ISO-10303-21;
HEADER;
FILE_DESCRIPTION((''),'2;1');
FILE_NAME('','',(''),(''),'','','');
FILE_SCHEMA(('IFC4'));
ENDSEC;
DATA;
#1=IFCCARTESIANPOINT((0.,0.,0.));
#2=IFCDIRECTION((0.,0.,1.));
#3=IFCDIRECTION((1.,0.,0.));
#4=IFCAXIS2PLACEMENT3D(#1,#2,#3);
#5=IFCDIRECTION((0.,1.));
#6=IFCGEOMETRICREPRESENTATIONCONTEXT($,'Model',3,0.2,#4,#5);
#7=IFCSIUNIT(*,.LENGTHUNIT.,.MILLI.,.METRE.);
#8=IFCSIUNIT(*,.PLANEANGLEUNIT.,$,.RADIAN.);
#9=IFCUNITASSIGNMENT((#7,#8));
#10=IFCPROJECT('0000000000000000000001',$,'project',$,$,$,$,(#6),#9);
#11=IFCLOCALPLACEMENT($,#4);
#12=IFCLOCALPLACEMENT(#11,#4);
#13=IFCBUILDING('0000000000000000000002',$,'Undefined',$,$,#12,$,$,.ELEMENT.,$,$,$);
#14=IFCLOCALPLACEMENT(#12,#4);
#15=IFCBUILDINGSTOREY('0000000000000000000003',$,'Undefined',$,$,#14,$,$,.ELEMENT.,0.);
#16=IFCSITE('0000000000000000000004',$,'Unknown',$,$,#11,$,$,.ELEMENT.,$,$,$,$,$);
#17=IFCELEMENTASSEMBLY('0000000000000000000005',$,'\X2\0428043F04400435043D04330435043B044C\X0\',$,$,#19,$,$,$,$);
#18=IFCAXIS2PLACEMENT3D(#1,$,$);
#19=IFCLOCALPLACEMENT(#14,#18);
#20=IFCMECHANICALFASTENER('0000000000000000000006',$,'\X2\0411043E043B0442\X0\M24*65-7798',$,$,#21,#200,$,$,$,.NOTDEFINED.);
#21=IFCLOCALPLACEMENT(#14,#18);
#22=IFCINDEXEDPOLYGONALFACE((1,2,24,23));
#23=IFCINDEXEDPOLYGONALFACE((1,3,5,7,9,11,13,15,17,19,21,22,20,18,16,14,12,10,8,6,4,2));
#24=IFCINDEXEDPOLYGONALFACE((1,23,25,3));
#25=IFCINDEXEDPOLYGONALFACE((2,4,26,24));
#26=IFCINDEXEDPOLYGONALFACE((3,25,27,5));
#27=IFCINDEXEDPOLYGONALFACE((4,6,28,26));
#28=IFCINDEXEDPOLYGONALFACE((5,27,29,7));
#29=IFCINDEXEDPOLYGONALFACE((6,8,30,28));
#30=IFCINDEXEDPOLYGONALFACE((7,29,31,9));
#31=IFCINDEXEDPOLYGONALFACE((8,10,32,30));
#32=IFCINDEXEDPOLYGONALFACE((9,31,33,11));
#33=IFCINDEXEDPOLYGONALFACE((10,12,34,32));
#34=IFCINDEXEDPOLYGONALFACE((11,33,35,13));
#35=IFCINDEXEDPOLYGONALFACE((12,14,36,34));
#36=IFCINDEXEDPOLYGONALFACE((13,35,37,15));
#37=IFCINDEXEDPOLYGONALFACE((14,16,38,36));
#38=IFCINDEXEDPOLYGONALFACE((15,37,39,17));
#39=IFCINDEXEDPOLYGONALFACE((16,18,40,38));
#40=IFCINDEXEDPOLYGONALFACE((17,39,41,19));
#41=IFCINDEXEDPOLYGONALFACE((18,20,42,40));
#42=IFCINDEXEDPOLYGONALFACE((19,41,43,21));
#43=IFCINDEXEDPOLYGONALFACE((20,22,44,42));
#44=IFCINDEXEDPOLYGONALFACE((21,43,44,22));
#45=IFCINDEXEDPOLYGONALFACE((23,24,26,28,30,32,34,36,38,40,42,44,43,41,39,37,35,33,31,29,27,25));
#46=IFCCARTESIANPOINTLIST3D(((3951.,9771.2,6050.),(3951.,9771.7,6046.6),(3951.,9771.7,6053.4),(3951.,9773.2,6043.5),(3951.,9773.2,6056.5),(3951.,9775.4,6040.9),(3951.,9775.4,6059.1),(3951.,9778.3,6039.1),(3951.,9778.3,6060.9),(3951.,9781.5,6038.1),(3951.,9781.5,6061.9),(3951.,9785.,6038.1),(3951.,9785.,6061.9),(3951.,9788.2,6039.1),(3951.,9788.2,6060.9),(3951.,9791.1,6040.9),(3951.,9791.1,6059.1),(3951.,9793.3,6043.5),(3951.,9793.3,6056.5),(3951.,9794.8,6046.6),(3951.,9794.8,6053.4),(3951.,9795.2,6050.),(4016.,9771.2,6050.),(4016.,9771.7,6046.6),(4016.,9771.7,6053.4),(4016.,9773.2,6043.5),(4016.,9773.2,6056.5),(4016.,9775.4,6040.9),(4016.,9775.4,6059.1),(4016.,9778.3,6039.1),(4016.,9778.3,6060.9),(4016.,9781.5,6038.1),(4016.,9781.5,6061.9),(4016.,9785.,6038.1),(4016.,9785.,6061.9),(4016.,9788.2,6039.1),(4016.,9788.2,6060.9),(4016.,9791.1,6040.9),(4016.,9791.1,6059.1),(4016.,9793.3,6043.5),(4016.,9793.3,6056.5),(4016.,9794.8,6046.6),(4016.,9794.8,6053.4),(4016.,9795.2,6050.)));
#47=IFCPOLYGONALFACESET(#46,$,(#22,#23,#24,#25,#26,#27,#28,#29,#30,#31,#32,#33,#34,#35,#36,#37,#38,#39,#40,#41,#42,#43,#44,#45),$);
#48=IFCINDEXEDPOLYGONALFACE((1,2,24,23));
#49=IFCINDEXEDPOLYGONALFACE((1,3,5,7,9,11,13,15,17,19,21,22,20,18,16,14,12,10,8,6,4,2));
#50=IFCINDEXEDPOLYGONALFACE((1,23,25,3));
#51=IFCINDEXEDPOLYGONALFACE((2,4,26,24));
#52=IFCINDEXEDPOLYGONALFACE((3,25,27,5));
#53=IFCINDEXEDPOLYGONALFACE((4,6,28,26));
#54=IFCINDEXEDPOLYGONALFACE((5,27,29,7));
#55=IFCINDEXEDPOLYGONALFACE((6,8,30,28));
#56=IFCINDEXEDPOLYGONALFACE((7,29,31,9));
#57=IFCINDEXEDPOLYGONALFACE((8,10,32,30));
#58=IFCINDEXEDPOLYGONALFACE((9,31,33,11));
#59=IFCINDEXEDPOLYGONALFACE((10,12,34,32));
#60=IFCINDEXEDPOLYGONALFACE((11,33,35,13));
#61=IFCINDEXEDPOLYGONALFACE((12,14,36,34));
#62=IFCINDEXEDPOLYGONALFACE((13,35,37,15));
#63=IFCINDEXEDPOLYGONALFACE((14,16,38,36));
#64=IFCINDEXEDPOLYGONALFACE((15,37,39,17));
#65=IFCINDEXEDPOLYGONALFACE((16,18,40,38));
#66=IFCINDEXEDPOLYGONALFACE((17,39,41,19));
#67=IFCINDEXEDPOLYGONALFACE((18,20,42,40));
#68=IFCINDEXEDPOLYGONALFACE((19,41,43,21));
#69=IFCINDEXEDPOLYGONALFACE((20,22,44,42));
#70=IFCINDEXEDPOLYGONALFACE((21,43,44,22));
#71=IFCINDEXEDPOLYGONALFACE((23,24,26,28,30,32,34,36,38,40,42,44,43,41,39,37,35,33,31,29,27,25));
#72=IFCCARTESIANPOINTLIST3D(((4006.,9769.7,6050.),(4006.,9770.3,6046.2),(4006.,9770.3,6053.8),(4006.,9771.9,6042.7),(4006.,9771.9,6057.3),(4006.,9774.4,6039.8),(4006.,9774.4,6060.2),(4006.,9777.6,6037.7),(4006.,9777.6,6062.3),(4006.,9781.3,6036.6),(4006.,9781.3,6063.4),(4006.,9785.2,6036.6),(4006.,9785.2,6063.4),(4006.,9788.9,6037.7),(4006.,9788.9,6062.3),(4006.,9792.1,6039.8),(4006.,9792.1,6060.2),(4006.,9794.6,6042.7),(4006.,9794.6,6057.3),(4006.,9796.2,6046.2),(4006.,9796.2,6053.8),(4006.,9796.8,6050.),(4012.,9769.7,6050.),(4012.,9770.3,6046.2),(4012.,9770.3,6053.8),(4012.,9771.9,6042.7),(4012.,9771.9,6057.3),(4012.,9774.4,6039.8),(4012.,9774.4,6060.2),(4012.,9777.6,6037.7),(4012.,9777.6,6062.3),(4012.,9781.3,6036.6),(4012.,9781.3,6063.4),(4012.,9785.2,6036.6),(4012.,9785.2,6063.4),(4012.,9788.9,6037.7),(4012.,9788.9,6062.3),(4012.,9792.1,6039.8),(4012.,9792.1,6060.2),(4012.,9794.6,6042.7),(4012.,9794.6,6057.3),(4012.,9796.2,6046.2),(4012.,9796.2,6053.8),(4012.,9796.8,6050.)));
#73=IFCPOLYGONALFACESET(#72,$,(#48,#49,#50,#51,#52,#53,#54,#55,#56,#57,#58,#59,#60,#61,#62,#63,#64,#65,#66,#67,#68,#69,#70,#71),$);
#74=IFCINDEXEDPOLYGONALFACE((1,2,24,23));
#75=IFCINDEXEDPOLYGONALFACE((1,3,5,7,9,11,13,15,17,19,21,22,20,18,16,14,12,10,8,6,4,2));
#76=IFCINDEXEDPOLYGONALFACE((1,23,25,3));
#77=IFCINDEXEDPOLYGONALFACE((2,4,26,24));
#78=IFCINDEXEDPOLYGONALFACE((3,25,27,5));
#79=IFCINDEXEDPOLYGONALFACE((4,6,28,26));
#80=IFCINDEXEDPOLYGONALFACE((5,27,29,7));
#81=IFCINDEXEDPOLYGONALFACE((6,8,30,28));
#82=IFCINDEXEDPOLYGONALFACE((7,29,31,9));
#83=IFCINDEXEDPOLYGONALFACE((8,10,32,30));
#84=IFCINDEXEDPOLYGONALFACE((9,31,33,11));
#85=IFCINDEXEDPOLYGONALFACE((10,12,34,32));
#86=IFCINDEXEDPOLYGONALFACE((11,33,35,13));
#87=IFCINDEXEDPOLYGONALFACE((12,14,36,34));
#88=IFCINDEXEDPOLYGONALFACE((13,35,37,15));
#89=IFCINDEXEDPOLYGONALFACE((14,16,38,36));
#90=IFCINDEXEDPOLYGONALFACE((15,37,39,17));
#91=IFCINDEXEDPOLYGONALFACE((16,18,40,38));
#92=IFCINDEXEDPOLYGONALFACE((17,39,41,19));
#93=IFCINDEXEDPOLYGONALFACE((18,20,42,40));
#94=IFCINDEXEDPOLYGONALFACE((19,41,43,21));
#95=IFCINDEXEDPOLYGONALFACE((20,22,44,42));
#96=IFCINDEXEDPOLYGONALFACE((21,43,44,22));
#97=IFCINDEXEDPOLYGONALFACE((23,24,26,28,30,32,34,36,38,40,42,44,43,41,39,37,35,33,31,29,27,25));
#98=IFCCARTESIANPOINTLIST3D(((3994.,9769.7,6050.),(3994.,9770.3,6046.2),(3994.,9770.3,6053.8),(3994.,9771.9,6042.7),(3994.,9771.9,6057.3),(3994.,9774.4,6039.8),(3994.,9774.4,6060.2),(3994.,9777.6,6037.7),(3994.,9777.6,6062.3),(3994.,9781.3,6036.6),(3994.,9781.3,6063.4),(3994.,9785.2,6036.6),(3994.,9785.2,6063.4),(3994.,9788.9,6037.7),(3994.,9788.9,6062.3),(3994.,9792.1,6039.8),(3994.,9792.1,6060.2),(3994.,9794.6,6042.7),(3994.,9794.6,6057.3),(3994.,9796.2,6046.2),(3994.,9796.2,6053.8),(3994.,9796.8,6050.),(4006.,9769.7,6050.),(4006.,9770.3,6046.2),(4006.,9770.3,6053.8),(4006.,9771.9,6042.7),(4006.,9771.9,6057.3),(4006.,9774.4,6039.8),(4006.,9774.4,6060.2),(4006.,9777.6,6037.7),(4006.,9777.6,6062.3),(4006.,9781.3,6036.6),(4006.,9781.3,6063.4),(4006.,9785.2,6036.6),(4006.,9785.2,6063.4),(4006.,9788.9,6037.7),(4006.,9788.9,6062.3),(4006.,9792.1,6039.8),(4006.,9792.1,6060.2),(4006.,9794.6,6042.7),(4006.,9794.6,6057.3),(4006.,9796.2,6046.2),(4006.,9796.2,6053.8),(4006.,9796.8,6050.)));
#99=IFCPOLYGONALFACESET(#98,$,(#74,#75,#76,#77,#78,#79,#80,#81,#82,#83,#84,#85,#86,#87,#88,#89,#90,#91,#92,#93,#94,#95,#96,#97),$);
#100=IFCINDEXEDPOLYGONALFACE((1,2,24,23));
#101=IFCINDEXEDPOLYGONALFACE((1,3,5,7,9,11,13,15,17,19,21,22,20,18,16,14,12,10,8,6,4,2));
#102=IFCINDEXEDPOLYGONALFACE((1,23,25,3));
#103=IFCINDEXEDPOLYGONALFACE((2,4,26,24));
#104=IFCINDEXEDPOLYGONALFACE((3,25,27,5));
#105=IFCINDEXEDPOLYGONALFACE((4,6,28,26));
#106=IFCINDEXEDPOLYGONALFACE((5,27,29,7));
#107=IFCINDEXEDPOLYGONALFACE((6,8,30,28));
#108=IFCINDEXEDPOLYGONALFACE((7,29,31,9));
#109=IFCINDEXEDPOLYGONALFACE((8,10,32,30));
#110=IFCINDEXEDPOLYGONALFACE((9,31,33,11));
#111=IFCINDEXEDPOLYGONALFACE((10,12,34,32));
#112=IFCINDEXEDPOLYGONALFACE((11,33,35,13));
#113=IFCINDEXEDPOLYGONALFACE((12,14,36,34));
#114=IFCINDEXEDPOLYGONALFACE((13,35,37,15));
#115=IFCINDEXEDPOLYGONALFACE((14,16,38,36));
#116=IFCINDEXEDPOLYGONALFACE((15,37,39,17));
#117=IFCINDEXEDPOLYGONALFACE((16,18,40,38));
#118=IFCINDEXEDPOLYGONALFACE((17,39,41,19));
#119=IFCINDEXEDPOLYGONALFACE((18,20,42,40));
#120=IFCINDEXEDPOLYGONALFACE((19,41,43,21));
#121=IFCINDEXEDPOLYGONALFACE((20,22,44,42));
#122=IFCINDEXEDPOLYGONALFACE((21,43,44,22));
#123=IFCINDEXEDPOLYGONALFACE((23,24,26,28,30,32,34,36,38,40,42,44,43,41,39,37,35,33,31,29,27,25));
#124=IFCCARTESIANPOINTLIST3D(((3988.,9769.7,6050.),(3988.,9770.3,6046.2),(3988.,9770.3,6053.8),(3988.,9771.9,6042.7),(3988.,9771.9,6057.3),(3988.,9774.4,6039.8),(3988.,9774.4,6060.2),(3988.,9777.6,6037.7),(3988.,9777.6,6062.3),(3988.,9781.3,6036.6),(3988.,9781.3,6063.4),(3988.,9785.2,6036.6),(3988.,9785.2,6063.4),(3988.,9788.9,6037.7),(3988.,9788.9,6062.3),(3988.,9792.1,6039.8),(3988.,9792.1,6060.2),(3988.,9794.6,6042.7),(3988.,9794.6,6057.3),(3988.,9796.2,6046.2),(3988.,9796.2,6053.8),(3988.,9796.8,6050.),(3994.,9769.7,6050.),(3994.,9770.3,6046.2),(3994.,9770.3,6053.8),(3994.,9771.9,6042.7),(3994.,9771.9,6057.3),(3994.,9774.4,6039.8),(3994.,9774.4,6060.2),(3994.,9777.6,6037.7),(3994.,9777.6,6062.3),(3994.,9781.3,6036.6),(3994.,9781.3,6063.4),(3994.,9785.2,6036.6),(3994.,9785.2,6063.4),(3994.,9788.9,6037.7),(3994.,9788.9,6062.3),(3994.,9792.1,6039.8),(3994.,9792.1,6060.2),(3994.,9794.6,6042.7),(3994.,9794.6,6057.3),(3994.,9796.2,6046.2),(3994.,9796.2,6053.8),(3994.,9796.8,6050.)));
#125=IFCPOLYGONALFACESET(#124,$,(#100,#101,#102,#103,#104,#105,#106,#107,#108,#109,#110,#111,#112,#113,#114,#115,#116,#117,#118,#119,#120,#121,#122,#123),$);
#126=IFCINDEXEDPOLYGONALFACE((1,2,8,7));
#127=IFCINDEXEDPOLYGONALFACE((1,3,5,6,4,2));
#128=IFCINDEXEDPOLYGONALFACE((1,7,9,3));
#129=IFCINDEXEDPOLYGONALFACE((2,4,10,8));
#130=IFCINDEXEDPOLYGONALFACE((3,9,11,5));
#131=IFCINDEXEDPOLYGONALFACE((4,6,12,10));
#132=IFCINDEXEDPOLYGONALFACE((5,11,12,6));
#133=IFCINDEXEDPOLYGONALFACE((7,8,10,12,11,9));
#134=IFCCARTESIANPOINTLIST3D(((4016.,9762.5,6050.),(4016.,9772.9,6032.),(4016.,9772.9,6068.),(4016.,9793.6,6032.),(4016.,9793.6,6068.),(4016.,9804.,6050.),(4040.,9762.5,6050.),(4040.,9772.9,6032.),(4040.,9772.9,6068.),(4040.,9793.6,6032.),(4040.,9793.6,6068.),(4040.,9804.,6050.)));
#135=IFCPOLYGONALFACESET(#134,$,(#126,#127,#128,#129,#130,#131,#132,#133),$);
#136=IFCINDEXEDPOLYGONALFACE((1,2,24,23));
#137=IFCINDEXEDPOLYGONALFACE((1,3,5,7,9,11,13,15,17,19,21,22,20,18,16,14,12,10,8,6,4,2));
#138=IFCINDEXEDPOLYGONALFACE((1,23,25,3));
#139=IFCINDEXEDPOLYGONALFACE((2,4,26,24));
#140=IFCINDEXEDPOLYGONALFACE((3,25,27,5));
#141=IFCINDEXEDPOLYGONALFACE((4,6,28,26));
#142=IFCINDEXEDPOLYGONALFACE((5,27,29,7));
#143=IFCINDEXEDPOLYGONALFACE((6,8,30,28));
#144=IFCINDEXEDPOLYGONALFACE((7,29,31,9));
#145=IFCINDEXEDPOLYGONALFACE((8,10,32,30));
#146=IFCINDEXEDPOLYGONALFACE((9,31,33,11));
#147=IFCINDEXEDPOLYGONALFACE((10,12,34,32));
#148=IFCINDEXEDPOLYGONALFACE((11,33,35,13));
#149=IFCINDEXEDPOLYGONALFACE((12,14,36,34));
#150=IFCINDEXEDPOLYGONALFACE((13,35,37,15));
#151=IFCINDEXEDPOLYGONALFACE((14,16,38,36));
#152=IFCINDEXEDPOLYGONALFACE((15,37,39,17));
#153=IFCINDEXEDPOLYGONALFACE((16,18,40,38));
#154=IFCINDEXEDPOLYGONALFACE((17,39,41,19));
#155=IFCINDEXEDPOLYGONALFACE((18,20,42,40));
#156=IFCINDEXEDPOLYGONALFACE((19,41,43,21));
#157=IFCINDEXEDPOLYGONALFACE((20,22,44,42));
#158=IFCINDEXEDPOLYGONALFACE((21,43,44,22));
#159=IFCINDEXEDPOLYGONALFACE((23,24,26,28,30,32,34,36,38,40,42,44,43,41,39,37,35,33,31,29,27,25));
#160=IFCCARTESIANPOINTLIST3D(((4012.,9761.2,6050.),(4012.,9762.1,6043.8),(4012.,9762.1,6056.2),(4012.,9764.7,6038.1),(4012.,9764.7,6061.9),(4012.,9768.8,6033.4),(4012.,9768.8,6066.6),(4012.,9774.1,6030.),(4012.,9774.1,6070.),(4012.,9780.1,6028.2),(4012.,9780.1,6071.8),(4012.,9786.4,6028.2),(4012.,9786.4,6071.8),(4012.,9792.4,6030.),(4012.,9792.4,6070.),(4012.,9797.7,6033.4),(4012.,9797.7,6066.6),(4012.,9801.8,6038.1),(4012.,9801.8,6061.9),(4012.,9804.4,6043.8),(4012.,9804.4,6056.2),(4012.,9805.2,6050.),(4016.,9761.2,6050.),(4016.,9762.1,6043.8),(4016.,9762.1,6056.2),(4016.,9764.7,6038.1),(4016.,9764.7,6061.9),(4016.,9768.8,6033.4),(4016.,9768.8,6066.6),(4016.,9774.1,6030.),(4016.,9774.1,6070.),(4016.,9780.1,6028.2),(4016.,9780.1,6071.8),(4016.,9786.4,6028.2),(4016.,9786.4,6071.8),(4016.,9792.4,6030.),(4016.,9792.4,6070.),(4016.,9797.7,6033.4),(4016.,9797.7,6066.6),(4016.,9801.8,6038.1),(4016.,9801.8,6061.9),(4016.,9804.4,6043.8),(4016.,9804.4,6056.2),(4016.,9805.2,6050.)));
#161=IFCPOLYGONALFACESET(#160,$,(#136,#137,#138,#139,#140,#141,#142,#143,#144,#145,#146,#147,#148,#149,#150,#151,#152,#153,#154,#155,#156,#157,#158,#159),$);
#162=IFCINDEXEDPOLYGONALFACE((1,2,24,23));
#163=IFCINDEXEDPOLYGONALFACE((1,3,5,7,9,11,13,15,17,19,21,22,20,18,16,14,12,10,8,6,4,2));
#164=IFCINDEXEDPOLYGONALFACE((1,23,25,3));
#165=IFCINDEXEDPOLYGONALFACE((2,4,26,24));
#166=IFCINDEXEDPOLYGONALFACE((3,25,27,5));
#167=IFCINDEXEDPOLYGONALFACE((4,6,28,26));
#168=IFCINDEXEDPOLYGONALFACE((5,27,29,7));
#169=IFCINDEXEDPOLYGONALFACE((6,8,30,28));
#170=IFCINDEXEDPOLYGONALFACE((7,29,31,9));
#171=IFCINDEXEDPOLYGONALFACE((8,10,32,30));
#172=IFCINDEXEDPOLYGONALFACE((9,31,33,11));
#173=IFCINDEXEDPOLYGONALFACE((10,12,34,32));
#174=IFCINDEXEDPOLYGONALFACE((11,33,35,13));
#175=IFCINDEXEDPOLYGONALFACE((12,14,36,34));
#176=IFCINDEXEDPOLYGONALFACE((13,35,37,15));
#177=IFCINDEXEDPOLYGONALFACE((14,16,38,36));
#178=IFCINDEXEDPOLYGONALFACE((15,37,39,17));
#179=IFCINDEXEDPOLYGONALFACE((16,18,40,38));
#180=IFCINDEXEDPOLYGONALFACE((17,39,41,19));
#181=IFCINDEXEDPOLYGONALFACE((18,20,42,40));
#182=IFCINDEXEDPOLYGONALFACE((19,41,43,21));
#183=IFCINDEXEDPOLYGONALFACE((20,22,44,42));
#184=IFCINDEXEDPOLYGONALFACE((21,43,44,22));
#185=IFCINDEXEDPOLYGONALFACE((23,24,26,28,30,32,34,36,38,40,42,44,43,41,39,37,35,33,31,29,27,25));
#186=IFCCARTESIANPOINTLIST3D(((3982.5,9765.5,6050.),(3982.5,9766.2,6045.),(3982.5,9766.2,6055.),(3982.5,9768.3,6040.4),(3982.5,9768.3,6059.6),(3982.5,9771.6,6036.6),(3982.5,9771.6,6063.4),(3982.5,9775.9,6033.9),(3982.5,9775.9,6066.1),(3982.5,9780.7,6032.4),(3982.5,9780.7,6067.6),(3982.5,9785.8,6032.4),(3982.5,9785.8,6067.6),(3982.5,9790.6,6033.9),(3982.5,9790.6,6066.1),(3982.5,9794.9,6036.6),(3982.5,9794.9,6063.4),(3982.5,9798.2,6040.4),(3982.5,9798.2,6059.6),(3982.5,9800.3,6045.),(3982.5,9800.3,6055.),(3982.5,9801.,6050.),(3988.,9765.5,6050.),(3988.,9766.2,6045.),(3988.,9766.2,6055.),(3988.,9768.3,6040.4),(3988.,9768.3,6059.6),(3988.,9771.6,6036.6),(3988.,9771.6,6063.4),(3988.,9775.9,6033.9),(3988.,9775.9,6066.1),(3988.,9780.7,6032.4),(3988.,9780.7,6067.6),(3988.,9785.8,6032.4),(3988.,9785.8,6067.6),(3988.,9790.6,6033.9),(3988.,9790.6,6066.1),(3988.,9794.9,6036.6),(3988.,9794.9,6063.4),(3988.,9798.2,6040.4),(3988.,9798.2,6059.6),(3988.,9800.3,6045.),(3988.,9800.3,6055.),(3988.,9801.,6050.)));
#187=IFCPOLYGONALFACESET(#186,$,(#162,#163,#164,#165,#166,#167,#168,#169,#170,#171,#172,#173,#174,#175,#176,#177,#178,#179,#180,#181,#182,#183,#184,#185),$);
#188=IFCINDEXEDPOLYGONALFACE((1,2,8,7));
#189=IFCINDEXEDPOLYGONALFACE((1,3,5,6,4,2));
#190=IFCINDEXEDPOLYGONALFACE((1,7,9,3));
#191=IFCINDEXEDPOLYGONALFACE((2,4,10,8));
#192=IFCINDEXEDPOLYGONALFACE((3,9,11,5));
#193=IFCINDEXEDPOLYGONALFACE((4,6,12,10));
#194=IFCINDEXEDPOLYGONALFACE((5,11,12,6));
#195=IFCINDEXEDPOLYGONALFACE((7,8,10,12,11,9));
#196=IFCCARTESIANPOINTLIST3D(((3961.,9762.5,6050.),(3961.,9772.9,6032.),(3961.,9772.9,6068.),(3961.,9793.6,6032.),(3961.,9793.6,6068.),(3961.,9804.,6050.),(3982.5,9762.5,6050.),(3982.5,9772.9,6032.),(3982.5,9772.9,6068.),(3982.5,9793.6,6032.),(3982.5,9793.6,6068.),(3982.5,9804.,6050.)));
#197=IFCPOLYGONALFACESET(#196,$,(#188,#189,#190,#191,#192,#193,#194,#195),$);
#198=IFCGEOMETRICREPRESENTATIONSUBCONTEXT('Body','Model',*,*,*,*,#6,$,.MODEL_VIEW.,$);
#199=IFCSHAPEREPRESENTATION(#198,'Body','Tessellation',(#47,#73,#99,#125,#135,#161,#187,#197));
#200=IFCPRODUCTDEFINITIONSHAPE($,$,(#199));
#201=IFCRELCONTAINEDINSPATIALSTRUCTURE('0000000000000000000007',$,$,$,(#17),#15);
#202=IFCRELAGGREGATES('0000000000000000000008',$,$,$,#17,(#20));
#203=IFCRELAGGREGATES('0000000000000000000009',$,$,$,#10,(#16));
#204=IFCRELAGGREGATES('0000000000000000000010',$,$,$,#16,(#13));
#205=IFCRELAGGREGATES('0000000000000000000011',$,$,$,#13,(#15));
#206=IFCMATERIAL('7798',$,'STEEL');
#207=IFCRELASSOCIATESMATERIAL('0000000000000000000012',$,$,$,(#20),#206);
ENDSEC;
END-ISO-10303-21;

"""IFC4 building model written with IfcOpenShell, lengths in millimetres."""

from ifc_helpers import new_model, si_unit, direction, frame, origin_with_axes, place, context, subcontext, project, spatial, line, arc, indexed_curve, outline, extrude, source, transform, mapped, material, element, aggregate, save


model = new_model("IFC4")

# Units and contexts
model_context = context("Model", 3, precision=0.2, world=origin_with_axes(), true_north=direction((0.0, 1.0)))
body_context = subcontext(model_context, "Body", "Model", "MODEL_VIEW")
ifc_project = project(units=[si_unit("LENGTHUNIT", "METRE", prefix="MILLI"), si_unit("PLANEANGLEUNIT", "RADIAN")], contexts=[model_context])

# Site, building, storey
site_placement = place(None, origin_with_axes())
site = spatial("IfcSite", under=ifc_project, at=site_placement, Name="Unknown", CompositionType="ELEMENT")
building_placement = place(site_placement, origin_with_axes())
building = spatial("IfcBuilding", under=site, at=building_placement, Name="Undefined", CompositionType="ELEMENT")
storey_placement = place(building_placement, origin_with_axes())
storey = spatial("IfcBuildingStorey", under=building, at=storey_placement, Name="Undefined", CompositionType="ELEMENT", Elevation=0.0)

# Shared definitions
ifc_material_1 = material(Name="7798", Category="STEEL")

# Element assembly, mechanical fastener
assembly_1_placement = place(storey_placement, frame((3949.0, 5673.0, 6045.0), z_axis=(0.0, 0.0, 1.0), x_axis=(0.0, 1.0, 0.0)))
assembly_1 = element("IfcElementAssembly", 1, at=assembly_1_placement, inside=storey, Name="Шпренгель")
shared_shape_1 = source(origin_with_axes(), body_context, "Body", "SweptSolid", [
    extrude(outline(indexed_curve([(12.0, 0.0), (0.0, 12.0), (-12.0, 0.0), (0.0, -12.0)], segments=[arc(1, 2, 3), arc(3, 4, 1)])), frame((0.0, 0.0, 16.0), z_axis=(0.0, 0.0, -1.0), x_axis=(0.0, 1.0, 0.0)), (0.0, 0.0, 1.0), 65.0),
    extrude(outline(indexed_curve([(13.5, 0.0), (0.0, 13.5), (-13.5, 0.0), (0.0, -13.5)], segments=[arc(1, 2, 3), arc(3, 4, 1)])), frame((0.0, 0.0, 12.0), z_axis=(0.0, 0.0, -1.0), x_axis=(0.0, 1.0, 0.0)), (0.0, 0.0, 1.0), 6.0),
    extrude(outline(indexed_curve([(13.5, 0.0), (0.0, 13.5), (-13.5, 0.0), (0.0, -13.5)], segments=[arc(1, 2, 3), arc(3, 4, 1)])), frame((0.0, 0.0, 6.0), z_axis=(0.0, 0.0, -1.0), x_axis=(0.0, 1.0, 0.0)), (0.0, 0.0, 1.0), 12.0),
    extrude(outline(indexed_curve([(13.5, 0.0), (0.0, 13.5), (-13.5, 0.0), (0.0, -13.5)], segments=[arc(1, 2, 3), arc(3, 4, 1)])), frame((0.0, 0.0, -6.0), z_axis=(0.0, 0.0, -1.0), x_axis=(0.0, 1.0, 0.0)), (0.0, 0.0, 1.0), 6.0),
    extrude(outline(indexed_curve([(20.8, 0.0), (10.4, 18.0), (-10.4, 18.0), (-20.8, 0.0), (-10.4, -18.0), (10.4, -18.0)], segments=[line(1, 2, 3, 4, 5, 6, 1)])), frame((0.0, 0.0, 40.0), z_axis=(0.0, 0.0, -1.0), x_axis=(0.0, 1.0, 0.0)), (0.0, 0.0, 1.0), 24.0),
    extrude(outline(indexed_curve([(22.0, 0.0), (0.0, 22.0), (-22.0, 0.0), (0.0, -22.0)], segments=[arc(1, 2, 3), arc(3, 4, 1)])), frame((0.0, 0.0, 16.0), z_axis=(0.0, 0.0, -1.0), x_axis=(0.0, 1.0, 0.0)), (0.0, 0.0, 1.0), 4.0),
    extrude(outline(indexed_curve([(17.8, 0.0), (0.0, 17.8), (-17.8, 0.0), (0.0, -17.8)], segments=[arc(1, 2, 3), arc(3, 4, 1)])), frame((0.0, 0.0, -12.0), z_axis=(0.0, 0.0, -1.0), x_axis=(0.0, 1.0, 0.0)), (0.0, 0.0, 1.0), 5.5),
    extrude(outline(indexed_curve([(20.8, 0.0), (10.4, 18.0), (-10.4, 18.0), (-20.8, 0.0), (-10.4, -18.0), (10.4, -18.0)], segments=[line(1, 2, 3, 4, 5, 6, 1)])), frame((0.0, 0.0, -17.5), z_axis=(0.0, 0.0, -1.0), x_axis=(0.0, 1.0, 0.0)), (0.0, 0.0, 1.0), 21.5),
])
mechanical_fastener_1_placement = place(assembly_1_placement, frame((4110.2, -51.0, 5.0), z_axis=(0.0, -1.0, 0.0), x_axis=(0.0, 0.0, 1.0)))
mechanical_fastener_1 = element("IfcMechanicalFastener", 2, at=mechanical_fastener_1_placement, material=ifc_material_1, Name="БолтM24*65-7798", PredefinedType="NOTDEFINED", context=body_context, shape_type="MappedRepresentation", body=[
    mapped(shared_shape_1, transform((0.0, 0.0, 0.0))),
])
aggregate(assembly_1, [mechanical_fastener_1])

save(model, "model.ifc")
